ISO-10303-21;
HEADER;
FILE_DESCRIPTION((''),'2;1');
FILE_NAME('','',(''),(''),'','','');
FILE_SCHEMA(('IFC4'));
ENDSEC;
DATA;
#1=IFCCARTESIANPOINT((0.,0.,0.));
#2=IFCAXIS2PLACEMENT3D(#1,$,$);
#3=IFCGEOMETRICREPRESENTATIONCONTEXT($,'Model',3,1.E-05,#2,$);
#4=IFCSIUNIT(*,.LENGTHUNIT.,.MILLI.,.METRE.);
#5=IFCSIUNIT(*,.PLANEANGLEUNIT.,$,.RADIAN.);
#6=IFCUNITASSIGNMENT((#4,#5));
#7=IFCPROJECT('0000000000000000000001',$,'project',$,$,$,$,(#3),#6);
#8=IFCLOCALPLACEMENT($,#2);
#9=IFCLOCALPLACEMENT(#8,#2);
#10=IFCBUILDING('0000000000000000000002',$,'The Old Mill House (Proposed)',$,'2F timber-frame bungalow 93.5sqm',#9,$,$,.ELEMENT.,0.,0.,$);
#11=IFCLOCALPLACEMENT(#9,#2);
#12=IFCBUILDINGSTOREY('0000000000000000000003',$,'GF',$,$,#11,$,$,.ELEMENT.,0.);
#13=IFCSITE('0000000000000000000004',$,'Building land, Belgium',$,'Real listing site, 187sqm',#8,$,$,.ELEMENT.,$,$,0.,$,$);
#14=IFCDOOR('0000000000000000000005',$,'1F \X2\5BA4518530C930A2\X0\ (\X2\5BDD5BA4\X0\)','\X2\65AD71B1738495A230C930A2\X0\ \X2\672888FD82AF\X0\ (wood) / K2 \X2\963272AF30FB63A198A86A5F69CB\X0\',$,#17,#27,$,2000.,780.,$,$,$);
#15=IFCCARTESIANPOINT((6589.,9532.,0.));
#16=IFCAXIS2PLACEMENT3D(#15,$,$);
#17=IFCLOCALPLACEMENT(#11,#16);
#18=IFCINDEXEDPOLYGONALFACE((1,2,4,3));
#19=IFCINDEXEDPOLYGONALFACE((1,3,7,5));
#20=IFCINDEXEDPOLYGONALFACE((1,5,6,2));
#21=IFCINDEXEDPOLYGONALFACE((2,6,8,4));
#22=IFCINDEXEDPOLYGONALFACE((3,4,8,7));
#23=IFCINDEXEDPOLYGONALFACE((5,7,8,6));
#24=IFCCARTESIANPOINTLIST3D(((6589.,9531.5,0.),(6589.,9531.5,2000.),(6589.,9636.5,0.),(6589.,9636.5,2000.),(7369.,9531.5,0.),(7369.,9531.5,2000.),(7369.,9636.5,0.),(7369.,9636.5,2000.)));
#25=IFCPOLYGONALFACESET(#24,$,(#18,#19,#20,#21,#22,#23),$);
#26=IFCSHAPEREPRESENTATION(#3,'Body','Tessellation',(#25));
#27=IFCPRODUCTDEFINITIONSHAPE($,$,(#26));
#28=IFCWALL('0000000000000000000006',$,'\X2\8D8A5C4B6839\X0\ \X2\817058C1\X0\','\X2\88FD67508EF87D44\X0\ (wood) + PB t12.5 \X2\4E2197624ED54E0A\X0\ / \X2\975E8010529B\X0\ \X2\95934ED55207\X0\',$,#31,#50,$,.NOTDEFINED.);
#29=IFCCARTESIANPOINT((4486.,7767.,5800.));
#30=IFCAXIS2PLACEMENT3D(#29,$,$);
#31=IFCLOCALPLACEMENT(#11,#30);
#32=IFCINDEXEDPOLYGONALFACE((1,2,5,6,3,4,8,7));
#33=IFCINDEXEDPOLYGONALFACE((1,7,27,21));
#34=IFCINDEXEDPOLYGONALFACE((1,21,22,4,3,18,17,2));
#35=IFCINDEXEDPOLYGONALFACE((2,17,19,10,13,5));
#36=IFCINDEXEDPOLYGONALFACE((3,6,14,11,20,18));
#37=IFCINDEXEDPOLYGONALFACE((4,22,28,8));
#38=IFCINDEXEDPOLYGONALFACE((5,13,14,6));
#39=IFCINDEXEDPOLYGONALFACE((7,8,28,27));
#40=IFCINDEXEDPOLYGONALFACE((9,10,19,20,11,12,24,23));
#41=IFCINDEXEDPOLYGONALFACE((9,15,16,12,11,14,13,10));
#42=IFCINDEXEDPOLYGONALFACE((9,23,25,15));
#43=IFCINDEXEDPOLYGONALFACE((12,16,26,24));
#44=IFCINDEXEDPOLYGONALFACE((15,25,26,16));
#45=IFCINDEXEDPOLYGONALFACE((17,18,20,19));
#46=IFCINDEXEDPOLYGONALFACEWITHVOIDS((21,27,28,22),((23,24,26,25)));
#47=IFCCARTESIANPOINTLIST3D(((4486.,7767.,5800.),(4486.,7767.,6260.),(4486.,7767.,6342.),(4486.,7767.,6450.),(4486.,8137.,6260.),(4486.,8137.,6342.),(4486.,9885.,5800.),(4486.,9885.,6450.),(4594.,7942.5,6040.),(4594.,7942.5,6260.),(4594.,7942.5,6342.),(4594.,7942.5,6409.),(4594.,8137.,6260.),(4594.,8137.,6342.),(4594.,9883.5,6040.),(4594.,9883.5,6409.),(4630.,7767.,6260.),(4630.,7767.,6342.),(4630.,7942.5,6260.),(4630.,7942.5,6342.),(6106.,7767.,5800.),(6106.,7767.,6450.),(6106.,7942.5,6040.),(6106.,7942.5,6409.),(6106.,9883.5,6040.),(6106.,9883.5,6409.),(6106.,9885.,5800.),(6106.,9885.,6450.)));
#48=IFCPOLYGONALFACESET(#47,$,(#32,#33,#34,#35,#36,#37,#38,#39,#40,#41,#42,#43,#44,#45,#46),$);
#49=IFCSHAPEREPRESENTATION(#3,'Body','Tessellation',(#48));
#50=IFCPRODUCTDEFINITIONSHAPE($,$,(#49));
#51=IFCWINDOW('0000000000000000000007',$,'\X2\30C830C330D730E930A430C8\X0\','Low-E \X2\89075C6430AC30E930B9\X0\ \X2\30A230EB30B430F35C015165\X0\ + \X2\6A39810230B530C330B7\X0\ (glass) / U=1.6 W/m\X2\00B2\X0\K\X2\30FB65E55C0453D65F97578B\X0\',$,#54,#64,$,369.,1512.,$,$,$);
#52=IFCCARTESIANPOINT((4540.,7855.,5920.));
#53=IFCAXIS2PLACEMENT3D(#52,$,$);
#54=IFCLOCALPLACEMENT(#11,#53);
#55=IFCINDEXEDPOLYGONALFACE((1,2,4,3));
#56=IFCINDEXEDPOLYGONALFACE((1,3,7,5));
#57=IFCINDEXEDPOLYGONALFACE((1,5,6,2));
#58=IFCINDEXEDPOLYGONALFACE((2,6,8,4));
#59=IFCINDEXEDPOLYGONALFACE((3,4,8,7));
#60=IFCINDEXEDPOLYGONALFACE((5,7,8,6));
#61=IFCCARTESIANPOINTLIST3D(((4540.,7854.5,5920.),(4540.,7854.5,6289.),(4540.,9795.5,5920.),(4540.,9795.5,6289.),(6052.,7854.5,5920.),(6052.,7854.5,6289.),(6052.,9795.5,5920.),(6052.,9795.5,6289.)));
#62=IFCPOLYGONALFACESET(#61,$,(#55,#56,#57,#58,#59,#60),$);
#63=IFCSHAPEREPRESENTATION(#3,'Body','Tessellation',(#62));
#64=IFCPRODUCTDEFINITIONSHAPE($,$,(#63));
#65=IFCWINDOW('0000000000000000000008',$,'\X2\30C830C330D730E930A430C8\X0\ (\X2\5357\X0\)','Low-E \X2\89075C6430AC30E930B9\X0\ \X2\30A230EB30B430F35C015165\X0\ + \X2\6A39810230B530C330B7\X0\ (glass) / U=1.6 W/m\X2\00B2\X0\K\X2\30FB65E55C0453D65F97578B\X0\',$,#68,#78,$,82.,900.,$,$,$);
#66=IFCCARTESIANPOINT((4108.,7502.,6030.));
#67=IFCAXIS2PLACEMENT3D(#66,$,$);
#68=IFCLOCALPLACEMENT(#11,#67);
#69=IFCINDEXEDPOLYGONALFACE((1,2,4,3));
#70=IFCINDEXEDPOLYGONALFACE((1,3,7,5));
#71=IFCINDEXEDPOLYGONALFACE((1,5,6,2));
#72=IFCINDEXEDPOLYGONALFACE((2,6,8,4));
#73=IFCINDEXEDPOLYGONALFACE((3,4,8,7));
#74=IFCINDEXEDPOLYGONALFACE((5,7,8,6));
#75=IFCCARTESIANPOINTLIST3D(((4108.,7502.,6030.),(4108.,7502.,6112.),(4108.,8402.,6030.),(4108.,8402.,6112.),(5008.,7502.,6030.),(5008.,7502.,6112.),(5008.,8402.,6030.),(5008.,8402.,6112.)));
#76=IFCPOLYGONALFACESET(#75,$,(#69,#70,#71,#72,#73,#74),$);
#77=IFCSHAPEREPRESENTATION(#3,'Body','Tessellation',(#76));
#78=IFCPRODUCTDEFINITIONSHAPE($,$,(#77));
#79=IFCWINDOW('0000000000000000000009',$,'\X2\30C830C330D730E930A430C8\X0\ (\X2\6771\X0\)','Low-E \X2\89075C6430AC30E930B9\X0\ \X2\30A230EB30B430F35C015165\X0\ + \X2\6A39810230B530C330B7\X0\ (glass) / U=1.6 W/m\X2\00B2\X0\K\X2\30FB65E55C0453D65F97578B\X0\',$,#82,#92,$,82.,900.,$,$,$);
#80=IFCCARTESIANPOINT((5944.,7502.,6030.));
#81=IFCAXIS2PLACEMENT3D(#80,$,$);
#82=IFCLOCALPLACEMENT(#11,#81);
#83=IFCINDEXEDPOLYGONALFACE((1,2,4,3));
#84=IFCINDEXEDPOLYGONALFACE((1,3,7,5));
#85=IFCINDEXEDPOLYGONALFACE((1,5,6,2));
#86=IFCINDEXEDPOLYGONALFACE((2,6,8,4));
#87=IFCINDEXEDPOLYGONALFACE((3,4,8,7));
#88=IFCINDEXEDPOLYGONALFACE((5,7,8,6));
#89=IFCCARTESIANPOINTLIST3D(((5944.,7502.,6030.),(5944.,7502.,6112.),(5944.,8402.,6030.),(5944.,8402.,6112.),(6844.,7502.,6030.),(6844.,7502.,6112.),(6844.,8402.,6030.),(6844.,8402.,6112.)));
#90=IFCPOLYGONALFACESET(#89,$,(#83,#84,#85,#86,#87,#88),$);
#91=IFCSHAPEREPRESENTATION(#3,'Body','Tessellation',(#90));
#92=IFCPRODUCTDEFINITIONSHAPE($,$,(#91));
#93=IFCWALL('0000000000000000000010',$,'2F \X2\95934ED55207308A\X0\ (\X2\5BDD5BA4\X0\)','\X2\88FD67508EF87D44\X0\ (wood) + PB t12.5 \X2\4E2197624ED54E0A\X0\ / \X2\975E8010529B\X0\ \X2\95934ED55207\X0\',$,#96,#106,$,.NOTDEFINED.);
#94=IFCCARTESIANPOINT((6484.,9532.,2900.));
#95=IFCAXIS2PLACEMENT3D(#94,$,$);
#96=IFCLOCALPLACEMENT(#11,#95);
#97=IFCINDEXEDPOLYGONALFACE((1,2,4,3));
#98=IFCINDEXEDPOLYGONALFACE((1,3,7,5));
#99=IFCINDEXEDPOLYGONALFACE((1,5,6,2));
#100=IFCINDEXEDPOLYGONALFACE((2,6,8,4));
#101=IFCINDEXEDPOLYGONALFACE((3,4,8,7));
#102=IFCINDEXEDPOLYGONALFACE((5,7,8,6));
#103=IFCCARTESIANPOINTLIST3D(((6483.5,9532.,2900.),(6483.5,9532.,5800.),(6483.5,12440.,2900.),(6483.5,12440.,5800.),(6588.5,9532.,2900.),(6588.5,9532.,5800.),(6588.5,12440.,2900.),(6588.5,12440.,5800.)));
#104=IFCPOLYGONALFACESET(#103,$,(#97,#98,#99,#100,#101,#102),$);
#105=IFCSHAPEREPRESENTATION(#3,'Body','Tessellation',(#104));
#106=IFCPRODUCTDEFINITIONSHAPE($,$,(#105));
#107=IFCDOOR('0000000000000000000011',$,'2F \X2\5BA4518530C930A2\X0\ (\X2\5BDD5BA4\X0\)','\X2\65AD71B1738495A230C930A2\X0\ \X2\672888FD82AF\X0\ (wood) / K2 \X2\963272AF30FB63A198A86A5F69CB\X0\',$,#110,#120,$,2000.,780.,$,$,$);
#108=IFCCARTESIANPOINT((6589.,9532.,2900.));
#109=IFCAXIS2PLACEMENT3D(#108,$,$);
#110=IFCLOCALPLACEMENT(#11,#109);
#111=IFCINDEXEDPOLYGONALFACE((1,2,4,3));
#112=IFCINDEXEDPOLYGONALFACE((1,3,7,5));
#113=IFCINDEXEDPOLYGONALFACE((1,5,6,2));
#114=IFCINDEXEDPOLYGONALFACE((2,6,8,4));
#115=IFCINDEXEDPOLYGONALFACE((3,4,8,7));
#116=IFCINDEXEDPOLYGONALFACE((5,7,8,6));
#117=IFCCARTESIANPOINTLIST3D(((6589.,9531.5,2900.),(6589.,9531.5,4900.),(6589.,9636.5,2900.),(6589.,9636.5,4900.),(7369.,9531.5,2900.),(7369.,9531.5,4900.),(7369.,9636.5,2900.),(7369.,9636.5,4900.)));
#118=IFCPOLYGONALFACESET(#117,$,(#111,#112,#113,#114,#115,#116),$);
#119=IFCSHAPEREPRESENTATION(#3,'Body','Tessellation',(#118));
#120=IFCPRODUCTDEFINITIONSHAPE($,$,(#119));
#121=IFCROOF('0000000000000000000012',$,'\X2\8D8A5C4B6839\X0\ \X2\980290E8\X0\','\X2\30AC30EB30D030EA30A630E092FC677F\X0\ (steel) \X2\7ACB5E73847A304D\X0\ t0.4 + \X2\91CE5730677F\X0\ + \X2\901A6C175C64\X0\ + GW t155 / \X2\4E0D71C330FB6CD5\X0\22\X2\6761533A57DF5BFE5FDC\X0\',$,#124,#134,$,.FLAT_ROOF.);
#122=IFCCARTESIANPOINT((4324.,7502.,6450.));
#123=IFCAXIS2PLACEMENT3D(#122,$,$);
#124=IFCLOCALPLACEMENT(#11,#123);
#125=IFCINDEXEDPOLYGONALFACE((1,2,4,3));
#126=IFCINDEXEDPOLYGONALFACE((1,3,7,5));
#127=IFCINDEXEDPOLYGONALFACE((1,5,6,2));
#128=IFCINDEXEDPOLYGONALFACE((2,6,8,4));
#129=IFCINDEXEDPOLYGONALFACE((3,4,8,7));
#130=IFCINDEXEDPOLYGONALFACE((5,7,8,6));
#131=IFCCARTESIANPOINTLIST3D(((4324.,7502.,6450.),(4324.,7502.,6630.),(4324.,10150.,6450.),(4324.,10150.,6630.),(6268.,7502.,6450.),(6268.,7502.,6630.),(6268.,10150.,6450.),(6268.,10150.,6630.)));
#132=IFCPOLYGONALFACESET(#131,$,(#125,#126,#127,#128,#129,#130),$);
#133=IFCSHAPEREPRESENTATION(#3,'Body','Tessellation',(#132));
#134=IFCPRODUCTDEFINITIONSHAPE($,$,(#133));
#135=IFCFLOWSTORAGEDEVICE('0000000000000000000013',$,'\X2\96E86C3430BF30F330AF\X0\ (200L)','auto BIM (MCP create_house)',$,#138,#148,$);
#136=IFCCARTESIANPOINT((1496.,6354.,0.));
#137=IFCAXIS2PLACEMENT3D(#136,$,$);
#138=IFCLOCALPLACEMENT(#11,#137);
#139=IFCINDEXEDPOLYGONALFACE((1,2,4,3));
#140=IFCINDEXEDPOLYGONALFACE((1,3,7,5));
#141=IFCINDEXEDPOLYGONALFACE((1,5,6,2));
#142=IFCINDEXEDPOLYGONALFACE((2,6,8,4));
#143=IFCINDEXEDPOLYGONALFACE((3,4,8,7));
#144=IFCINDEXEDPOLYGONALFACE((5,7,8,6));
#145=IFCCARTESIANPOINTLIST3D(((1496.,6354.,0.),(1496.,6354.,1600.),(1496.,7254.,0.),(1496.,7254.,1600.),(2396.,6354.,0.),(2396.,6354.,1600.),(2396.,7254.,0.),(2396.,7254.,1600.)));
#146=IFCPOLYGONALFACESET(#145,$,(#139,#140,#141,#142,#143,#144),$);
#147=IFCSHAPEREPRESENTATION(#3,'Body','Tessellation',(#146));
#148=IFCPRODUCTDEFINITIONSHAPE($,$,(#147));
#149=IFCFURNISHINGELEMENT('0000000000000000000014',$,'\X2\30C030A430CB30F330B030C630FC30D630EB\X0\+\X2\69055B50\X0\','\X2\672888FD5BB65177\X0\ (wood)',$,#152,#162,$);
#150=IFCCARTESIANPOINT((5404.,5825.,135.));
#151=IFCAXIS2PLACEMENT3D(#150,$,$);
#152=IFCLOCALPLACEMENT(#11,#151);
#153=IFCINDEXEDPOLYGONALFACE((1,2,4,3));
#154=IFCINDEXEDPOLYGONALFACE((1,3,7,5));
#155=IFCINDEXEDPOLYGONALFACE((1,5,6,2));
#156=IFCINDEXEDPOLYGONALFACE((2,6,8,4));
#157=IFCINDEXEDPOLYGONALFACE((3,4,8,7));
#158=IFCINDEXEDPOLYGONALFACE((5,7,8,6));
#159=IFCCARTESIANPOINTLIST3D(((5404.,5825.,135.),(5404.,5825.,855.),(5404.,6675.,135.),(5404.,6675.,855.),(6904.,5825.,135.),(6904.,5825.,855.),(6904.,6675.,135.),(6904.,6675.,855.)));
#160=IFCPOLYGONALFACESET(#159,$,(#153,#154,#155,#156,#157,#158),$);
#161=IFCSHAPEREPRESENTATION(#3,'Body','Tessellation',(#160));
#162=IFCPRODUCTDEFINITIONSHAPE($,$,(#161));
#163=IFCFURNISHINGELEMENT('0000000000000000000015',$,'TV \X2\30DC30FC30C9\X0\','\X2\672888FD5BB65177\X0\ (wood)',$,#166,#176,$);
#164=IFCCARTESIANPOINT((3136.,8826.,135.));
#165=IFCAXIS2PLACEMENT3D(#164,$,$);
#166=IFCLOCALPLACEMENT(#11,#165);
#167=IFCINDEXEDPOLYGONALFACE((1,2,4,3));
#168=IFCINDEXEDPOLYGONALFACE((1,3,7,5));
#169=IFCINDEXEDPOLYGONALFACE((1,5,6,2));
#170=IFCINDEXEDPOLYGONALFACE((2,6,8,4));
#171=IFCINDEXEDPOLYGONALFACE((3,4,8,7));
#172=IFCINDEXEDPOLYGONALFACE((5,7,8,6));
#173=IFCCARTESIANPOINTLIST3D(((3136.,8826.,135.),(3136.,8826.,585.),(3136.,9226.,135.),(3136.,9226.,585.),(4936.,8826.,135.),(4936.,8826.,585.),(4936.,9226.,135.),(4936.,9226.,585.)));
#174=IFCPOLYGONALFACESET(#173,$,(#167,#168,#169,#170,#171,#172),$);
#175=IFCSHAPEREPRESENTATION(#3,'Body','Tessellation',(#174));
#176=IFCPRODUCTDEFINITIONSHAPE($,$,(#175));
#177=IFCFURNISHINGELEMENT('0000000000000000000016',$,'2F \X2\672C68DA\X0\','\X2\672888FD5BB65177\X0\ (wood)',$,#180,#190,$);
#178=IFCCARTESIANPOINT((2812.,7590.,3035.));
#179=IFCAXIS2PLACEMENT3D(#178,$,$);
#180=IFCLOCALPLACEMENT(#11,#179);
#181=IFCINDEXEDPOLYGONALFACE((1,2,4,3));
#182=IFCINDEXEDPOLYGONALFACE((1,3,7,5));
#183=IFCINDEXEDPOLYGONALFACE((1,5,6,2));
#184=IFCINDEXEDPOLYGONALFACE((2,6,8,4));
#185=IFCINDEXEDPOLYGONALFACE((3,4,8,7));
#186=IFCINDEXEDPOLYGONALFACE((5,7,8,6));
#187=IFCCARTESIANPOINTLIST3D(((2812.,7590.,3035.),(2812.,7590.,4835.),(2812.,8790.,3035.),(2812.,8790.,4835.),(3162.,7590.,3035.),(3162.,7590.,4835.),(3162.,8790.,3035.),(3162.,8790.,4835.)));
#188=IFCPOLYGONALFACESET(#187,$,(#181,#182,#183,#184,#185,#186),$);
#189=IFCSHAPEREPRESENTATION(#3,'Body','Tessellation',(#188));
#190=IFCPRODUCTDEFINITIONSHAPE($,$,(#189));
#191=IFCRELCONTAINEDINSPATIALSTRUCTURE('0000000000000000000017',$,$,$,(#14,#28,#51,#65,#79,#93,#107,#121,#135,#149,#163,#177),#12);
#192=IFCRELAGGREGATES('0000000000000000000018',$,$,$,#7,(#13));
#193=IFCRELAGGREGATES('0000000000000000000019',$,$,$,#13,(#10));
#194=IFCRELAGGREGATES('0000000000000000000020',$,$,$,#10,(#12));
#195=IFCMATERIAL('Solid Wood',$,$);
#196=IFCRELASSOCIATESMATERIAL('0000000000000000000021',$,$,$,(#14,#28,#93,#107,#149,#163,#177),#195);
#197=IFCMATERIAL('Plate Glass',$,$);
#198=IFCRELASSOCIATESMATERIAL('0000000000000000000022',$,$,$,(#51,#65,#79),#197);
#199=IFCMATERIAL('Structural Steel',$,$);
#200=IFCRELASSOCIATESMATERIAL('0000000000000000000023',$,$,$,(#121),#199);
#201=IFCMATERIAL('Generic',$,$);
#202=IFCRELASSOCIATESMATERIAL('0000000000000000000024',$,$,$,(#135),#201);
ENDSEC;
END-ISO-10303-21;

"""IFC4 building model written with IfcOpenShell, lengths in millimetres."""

from ifc_helpers import new_model, si_unit, frame, frame_2d, origin, place, context, project, spatial, rectangle, extrude, material, element, fill, save


model = new_model("IFC4")

# Units and contexts
model_context = context("Model", 3, precision=1e-05, world=origin())
ifc_project = project(units=[si_unit("LENGTHUNIT", "METRE", prefix="MILLI"), si_unit("PLANEANGLEUNIT", "RADIAN")], contexts=[model_context])

# Site, building, storey
site_placement = place(None, origin())
site = spatial("IfcSite", under=ifc_project, at=site_placement, Name="Building land, Belgium", ObjectType="Real listing site, 187sqm", CompositionType="ELEMENT", RefElevation=0.0)
building_placement = place(site_placement, origin())
building = spatial("IfcBuilding", under=site, at=building_placement, Name="The Old Mill House (Proposed)", ObjectType="2F timber-frame bungalow 93.5sqm", CompositionType="ELEMENT", ElevationOfRefHeight=0.0, ElevationOfTerrain=0.0)
storey_placement = place(building_placement, origin())
storey = spatial("IfcBuildingStorey", under=building, at=storey_placement, Name="GF", CompositionType="ELEMENT", Elevation=0.0)

# Shared definitions
ifc_material_1 = material(Name="Solid Wood")

# Door
door_1_placement = place(storey_placement, frame((6589.0, 9532.0, 0.0)))
element("IfcDoor", 1, at=door_1_placement, inside=storey, material=ifc_material_1, Name="1F 室内ドア (寝室)", Description="断熱玄関ドア 木製芯 (wood) / K2 防犯・採風機構", OverallHeight=2000.0, OverallWidth=780.0, context=model_context, shape_type="SweptSolid", body=[
    extrude(rectangle(XDim=780.0, YDim=105.0, at=frame_2d((390.0, 52.0))), frame((6589.0, 9532.0, 0.0)), (0.0, 0.0, 1.0), 2000.0),
])

# Wall, openings, windows
wall_1_placement = place(storey_placement, frame((4486.0, 7767.0, 5800.0)))
wall_1 = element("IfcWall", 2, at=wall_1_placement, inside=storey, material=ifc_material_1, Name="越屋根 腰壁", Description="製材軸組 (wood) + PB t12.5 両面仕上 / 非耐力 間仕切", PredefinedType="NOTDEFINED", context=model_context, shape_type="SweptSolid", body=[
    extrude(rectangle(XDim=1620.0, YDim=2118.0, at=frame_2d((810.0, 1059.0))), frame((4486.0, 7767.0, 5800.0)), (0.0, 0.0, 1.0), 650.0),
])
opening_1_placement = place(storey_placement, frame((4540.0, 7855.0, 5920.0)))
opening_1 = element("IfcOpeningElement", 3, at=opening_1_placement, cuts=wall_1, PredefinedType="NOTDEFINED", context=model_context, shape_type="SweptSolid", body=[
    extrude(rectangle(XDim=1512.0, YDim=1941.0, at=frame_2d((756.0, 970.0))), frame((4540.0, 7855.0, 5920.0)), (0.0, 0.0, 1.0), 369.0),
])
opening_2_placement = place(storey_placement, frame((4108.0, 7502.0, 6030.0)))
opening_2 = element("IfcOpeningElement", 4, at=opening_2_placement, cuts=wall_1, PredefinedType="NOTDEFINED", context=model_context, shape_type="SweptSolid", body=[
    extrude(rectangle(XDim=900.0, YDim=900.0, at=frame_2d((450.0, 450.0))), frame((4108.0, 7502.0, 6030.0)), (0.0, 0.0, 1.0), 82.0),
])
opening_3_placement = place(storey_placement, frame((5944.0, 7502.0, 6030.0)))
opening_3 = element("IfcOpeningElement", 5, at=opening_3_placement, cuts=wall_1, PredefinedType="NOTDEFINED", context=model_context, shape_type="SweptSolid", body=[
    extrude(rectangle(XDim=900.0, YDim=900.0, at=frame_2d((450.0, 450.0))), frame((5944.0, 7502.0, 6030.0)), (0.0, 0.0, 1.0), 82.0),
])
ifc_material_2 = material(Name="Plate Glass")
window_1_placement = place(storey_placement, frame((4540.0, 7855.0, 5920.0)))
window_1 = element("IfcWindow", 6, at=window_1_placement, inside=storey, material=ifc_material_2, Name="トップライト", Description="Low-E 複層ガラス アルゴン封入 + 樹脂サッシ (glass) / U=1.6 W/m²K・日射取得型", OverallHeight=369.0, OverallWidth=1512.0, context=model_context, shape_type="SweptSolid", body=[
    extrude(rectangle(XDim=1512.0, YDim=1941.0, at=frame_2d((756.0, 970.0))), frame((4540.0, 7855.0, 5920.0)), (0.0, 0.0, 1.0), 369.0),
])
fill(opening_1, window_1)
window_2_placement = place(storey_placement, frame((4108.0, 7502.0, 6030.0)))
window_2 = element("IfcWindow", 7, at=window_2_placement, inside=storey, material=ifc_material_2, Name="トップライト (南)", Description="Low-E 複層ガラス アルゴン封入 + 樹脂サッシ (glass) / U=1.6 W/m²K・日射取得型", OverallHeight=82.0, OverallWidth=900.0, context=model_context, shape_type="SweptSolid", body=[
    extrude(rectangle(XDim=900.0, YDim=900.0, at=frame_2d((450.0, 450.0))), frame((4108.0, 7502.0, 6030.0)), (0.0, 0.0, 1.0), 82.0),
])
fill(opening_2, window_2)
window_3_placement = place(storey_placement, frame((5944.0, 7502.0, 6030.0)))
window_3 = element("IfcWindow", 8, at=window_3_placement, inside=storey, material=ifc_material_2, Name="トップライト (東)", Description="Low-E 複層ガラス アルゴン封入 + 樹脂サッシ (glass) / U=1.6 W/m²K・日射取得型", OverallHeight=82.0, OverallWidth=900.0, context=model_context, shape_type="SweptSolid", body=[
    extrude(rectangle(XDim=900.0, YDim=900.0, at=frame_2d((450.0, 450.0))), frame((5944.0, 7502.0, 6030.0)), (0.0, 0.0, 1.0), 82.0),
])
fill(opening_3, window_3)

# Wall
wall_2_placement = place(storey_placement, frame((6484.0, 9532.0, 2900.0)))
element("IfcWall", 9, at=wall_2_placement, inside=storey, material=ifc_material_1, Name="2F 間仕切り (寝室)", Description="製材軸組 (wood) + PB t12.5 両面仕上 / 非耐力 間仕切", PredefinedType="NOTDEFINED", context=model_context, shape_type="SweptSolid", body=[
    extrude(rectangle(XDim=105.0, YDim=2908.0, at=frame_2d((52.0, 1454.0))), frame((6484.0, 9532.0, 2900.0)), (0.0, 0.0, 1.0), 2900.0),
])

# Door
door_2_placement = place(storey_placement, frame((6589.0, 9532.0, 2900.0)))
element("IfcDoor", 10, at=door_2_placement, inside=storey, material=ifc_material_1, Name="2F 室内ドア (寝室)", Description="断熱玄関ドア 木製芯 (wood) / K2 防犯・採風機構", OverallHeight=2000.0, OverallWidth=780.0, context=model_context, shape_type="SweptSolid", body=[
    extrude(rectangle(XDim=780.0, YDim=105.0, at=frame_2d((390.0, 52.0))), frame((6589.0, 9532.0, 2900.0)), (0.0, 0.0, 1.0), 2000.0),
])

# Roof
ifc_material_3 = material(Name="Structural Steel")
roof_placement = place(storey_placement, frame((4324.0, 7502.0, 6450.0)))
element("IfcRoof", 11, at=roof_placement, inside=storey, material=ifc_material_3, Name="越屋根 頂部", Description="ガルバリウム鋼板 (steel) 立平葺き t0.4 + 野地板 + 通気層 + GW t155 / 不燃・法22条区域対応", PredefinedType="FLAT_ROOF", context=model_context, shape_type="SweptSolid", body=[
    extrude(rectangle(XDim=1944.0, YDim=2648.0, at=frame_2d((972.0, 1324.0))), frame((4324.0, 7502.0, 6450.0)), (0.0, 0.0, 1.0), 180.0),
])

# Flow storage device
ifc_material_4 = material(Name="Generic")
flow_storage_device_placement = place(storey_placement, frame((1496.0, 6354.0, 0.0)))
element("IfcFlowStorageDevice", 12, at=flow_storage_device_placement, inside=storey, material=ifc_material_4, Name="雨水タンク (200L)", Description="auto BIM (MCP create_house)", context=model_context, shape_type="SweptSolid", body=[
    extrude(rectangle(XDim=900.0, YDim=900.0, at=frame_2d((450.0, 450.0))), frame((1496.0, 6354.0, 0.0)), (0.0, 0.0, 1.0), 1600.0),
])

# Furnishing elements
furnishing_1_placement = place(storey_placement, frame((5404.0, 5825.0, 135.0)))
element("IfcFurnishingElement", 13, at=furnishing_1_placement, inside=storey, material=ifc_material_1, Name="ダイニングテーブル+椅子", Description="木製家具 (wood)", context=model_context, shape_type="SweptSolid", body=[
    extrude(rectangle(XDim=1500.0, YDim=850.0, at=frame_2d((750.0, 425.0))), frame((5404.0, 5825.0, 135.0)), (0.0, 0.0, 1.0), 720.0),
])
furnishing_2_placement = place(storey_placement, frame((3136.0, 8826.0, 135.0)))
element("IfcFurnishingElement", 14, at=furnishing_2_placement, inside=storey, material=ifc_material_1, Name="TV ボード", Description="木製家具 (wood)", context=model_context, shape_type="SweptSolid", body=[
    extrude(rectangle(XDim=1800.0, YDim=400.0, at=frame_2d((900.0, 200.0))), frame((3136.0, 8826.0, 135.0)), (0.0, 0.0, 1.0), 450.0),
])
furnishing_3_placement = place(storey_placement, frame((2812.0, 7590.0, 3035.0)))
element("IfcFurnishingElement", 15, at=furnishing_3_placement, inside=storey, material=ifc_material_1, Name="2F 本棚", Description="木製家具 (wood)", context=model_context, shape_type="SweptSolid", body=[
    extrude(rectangle(XDim=350.0, YDim=1200.0, at=frame_2d((175.0, 600.0))), frame((2812.0, 7590.0, 3035.0)), (0.0, 0.0, 1.0), 1800.0),
])

save(model, "model.ifc")
